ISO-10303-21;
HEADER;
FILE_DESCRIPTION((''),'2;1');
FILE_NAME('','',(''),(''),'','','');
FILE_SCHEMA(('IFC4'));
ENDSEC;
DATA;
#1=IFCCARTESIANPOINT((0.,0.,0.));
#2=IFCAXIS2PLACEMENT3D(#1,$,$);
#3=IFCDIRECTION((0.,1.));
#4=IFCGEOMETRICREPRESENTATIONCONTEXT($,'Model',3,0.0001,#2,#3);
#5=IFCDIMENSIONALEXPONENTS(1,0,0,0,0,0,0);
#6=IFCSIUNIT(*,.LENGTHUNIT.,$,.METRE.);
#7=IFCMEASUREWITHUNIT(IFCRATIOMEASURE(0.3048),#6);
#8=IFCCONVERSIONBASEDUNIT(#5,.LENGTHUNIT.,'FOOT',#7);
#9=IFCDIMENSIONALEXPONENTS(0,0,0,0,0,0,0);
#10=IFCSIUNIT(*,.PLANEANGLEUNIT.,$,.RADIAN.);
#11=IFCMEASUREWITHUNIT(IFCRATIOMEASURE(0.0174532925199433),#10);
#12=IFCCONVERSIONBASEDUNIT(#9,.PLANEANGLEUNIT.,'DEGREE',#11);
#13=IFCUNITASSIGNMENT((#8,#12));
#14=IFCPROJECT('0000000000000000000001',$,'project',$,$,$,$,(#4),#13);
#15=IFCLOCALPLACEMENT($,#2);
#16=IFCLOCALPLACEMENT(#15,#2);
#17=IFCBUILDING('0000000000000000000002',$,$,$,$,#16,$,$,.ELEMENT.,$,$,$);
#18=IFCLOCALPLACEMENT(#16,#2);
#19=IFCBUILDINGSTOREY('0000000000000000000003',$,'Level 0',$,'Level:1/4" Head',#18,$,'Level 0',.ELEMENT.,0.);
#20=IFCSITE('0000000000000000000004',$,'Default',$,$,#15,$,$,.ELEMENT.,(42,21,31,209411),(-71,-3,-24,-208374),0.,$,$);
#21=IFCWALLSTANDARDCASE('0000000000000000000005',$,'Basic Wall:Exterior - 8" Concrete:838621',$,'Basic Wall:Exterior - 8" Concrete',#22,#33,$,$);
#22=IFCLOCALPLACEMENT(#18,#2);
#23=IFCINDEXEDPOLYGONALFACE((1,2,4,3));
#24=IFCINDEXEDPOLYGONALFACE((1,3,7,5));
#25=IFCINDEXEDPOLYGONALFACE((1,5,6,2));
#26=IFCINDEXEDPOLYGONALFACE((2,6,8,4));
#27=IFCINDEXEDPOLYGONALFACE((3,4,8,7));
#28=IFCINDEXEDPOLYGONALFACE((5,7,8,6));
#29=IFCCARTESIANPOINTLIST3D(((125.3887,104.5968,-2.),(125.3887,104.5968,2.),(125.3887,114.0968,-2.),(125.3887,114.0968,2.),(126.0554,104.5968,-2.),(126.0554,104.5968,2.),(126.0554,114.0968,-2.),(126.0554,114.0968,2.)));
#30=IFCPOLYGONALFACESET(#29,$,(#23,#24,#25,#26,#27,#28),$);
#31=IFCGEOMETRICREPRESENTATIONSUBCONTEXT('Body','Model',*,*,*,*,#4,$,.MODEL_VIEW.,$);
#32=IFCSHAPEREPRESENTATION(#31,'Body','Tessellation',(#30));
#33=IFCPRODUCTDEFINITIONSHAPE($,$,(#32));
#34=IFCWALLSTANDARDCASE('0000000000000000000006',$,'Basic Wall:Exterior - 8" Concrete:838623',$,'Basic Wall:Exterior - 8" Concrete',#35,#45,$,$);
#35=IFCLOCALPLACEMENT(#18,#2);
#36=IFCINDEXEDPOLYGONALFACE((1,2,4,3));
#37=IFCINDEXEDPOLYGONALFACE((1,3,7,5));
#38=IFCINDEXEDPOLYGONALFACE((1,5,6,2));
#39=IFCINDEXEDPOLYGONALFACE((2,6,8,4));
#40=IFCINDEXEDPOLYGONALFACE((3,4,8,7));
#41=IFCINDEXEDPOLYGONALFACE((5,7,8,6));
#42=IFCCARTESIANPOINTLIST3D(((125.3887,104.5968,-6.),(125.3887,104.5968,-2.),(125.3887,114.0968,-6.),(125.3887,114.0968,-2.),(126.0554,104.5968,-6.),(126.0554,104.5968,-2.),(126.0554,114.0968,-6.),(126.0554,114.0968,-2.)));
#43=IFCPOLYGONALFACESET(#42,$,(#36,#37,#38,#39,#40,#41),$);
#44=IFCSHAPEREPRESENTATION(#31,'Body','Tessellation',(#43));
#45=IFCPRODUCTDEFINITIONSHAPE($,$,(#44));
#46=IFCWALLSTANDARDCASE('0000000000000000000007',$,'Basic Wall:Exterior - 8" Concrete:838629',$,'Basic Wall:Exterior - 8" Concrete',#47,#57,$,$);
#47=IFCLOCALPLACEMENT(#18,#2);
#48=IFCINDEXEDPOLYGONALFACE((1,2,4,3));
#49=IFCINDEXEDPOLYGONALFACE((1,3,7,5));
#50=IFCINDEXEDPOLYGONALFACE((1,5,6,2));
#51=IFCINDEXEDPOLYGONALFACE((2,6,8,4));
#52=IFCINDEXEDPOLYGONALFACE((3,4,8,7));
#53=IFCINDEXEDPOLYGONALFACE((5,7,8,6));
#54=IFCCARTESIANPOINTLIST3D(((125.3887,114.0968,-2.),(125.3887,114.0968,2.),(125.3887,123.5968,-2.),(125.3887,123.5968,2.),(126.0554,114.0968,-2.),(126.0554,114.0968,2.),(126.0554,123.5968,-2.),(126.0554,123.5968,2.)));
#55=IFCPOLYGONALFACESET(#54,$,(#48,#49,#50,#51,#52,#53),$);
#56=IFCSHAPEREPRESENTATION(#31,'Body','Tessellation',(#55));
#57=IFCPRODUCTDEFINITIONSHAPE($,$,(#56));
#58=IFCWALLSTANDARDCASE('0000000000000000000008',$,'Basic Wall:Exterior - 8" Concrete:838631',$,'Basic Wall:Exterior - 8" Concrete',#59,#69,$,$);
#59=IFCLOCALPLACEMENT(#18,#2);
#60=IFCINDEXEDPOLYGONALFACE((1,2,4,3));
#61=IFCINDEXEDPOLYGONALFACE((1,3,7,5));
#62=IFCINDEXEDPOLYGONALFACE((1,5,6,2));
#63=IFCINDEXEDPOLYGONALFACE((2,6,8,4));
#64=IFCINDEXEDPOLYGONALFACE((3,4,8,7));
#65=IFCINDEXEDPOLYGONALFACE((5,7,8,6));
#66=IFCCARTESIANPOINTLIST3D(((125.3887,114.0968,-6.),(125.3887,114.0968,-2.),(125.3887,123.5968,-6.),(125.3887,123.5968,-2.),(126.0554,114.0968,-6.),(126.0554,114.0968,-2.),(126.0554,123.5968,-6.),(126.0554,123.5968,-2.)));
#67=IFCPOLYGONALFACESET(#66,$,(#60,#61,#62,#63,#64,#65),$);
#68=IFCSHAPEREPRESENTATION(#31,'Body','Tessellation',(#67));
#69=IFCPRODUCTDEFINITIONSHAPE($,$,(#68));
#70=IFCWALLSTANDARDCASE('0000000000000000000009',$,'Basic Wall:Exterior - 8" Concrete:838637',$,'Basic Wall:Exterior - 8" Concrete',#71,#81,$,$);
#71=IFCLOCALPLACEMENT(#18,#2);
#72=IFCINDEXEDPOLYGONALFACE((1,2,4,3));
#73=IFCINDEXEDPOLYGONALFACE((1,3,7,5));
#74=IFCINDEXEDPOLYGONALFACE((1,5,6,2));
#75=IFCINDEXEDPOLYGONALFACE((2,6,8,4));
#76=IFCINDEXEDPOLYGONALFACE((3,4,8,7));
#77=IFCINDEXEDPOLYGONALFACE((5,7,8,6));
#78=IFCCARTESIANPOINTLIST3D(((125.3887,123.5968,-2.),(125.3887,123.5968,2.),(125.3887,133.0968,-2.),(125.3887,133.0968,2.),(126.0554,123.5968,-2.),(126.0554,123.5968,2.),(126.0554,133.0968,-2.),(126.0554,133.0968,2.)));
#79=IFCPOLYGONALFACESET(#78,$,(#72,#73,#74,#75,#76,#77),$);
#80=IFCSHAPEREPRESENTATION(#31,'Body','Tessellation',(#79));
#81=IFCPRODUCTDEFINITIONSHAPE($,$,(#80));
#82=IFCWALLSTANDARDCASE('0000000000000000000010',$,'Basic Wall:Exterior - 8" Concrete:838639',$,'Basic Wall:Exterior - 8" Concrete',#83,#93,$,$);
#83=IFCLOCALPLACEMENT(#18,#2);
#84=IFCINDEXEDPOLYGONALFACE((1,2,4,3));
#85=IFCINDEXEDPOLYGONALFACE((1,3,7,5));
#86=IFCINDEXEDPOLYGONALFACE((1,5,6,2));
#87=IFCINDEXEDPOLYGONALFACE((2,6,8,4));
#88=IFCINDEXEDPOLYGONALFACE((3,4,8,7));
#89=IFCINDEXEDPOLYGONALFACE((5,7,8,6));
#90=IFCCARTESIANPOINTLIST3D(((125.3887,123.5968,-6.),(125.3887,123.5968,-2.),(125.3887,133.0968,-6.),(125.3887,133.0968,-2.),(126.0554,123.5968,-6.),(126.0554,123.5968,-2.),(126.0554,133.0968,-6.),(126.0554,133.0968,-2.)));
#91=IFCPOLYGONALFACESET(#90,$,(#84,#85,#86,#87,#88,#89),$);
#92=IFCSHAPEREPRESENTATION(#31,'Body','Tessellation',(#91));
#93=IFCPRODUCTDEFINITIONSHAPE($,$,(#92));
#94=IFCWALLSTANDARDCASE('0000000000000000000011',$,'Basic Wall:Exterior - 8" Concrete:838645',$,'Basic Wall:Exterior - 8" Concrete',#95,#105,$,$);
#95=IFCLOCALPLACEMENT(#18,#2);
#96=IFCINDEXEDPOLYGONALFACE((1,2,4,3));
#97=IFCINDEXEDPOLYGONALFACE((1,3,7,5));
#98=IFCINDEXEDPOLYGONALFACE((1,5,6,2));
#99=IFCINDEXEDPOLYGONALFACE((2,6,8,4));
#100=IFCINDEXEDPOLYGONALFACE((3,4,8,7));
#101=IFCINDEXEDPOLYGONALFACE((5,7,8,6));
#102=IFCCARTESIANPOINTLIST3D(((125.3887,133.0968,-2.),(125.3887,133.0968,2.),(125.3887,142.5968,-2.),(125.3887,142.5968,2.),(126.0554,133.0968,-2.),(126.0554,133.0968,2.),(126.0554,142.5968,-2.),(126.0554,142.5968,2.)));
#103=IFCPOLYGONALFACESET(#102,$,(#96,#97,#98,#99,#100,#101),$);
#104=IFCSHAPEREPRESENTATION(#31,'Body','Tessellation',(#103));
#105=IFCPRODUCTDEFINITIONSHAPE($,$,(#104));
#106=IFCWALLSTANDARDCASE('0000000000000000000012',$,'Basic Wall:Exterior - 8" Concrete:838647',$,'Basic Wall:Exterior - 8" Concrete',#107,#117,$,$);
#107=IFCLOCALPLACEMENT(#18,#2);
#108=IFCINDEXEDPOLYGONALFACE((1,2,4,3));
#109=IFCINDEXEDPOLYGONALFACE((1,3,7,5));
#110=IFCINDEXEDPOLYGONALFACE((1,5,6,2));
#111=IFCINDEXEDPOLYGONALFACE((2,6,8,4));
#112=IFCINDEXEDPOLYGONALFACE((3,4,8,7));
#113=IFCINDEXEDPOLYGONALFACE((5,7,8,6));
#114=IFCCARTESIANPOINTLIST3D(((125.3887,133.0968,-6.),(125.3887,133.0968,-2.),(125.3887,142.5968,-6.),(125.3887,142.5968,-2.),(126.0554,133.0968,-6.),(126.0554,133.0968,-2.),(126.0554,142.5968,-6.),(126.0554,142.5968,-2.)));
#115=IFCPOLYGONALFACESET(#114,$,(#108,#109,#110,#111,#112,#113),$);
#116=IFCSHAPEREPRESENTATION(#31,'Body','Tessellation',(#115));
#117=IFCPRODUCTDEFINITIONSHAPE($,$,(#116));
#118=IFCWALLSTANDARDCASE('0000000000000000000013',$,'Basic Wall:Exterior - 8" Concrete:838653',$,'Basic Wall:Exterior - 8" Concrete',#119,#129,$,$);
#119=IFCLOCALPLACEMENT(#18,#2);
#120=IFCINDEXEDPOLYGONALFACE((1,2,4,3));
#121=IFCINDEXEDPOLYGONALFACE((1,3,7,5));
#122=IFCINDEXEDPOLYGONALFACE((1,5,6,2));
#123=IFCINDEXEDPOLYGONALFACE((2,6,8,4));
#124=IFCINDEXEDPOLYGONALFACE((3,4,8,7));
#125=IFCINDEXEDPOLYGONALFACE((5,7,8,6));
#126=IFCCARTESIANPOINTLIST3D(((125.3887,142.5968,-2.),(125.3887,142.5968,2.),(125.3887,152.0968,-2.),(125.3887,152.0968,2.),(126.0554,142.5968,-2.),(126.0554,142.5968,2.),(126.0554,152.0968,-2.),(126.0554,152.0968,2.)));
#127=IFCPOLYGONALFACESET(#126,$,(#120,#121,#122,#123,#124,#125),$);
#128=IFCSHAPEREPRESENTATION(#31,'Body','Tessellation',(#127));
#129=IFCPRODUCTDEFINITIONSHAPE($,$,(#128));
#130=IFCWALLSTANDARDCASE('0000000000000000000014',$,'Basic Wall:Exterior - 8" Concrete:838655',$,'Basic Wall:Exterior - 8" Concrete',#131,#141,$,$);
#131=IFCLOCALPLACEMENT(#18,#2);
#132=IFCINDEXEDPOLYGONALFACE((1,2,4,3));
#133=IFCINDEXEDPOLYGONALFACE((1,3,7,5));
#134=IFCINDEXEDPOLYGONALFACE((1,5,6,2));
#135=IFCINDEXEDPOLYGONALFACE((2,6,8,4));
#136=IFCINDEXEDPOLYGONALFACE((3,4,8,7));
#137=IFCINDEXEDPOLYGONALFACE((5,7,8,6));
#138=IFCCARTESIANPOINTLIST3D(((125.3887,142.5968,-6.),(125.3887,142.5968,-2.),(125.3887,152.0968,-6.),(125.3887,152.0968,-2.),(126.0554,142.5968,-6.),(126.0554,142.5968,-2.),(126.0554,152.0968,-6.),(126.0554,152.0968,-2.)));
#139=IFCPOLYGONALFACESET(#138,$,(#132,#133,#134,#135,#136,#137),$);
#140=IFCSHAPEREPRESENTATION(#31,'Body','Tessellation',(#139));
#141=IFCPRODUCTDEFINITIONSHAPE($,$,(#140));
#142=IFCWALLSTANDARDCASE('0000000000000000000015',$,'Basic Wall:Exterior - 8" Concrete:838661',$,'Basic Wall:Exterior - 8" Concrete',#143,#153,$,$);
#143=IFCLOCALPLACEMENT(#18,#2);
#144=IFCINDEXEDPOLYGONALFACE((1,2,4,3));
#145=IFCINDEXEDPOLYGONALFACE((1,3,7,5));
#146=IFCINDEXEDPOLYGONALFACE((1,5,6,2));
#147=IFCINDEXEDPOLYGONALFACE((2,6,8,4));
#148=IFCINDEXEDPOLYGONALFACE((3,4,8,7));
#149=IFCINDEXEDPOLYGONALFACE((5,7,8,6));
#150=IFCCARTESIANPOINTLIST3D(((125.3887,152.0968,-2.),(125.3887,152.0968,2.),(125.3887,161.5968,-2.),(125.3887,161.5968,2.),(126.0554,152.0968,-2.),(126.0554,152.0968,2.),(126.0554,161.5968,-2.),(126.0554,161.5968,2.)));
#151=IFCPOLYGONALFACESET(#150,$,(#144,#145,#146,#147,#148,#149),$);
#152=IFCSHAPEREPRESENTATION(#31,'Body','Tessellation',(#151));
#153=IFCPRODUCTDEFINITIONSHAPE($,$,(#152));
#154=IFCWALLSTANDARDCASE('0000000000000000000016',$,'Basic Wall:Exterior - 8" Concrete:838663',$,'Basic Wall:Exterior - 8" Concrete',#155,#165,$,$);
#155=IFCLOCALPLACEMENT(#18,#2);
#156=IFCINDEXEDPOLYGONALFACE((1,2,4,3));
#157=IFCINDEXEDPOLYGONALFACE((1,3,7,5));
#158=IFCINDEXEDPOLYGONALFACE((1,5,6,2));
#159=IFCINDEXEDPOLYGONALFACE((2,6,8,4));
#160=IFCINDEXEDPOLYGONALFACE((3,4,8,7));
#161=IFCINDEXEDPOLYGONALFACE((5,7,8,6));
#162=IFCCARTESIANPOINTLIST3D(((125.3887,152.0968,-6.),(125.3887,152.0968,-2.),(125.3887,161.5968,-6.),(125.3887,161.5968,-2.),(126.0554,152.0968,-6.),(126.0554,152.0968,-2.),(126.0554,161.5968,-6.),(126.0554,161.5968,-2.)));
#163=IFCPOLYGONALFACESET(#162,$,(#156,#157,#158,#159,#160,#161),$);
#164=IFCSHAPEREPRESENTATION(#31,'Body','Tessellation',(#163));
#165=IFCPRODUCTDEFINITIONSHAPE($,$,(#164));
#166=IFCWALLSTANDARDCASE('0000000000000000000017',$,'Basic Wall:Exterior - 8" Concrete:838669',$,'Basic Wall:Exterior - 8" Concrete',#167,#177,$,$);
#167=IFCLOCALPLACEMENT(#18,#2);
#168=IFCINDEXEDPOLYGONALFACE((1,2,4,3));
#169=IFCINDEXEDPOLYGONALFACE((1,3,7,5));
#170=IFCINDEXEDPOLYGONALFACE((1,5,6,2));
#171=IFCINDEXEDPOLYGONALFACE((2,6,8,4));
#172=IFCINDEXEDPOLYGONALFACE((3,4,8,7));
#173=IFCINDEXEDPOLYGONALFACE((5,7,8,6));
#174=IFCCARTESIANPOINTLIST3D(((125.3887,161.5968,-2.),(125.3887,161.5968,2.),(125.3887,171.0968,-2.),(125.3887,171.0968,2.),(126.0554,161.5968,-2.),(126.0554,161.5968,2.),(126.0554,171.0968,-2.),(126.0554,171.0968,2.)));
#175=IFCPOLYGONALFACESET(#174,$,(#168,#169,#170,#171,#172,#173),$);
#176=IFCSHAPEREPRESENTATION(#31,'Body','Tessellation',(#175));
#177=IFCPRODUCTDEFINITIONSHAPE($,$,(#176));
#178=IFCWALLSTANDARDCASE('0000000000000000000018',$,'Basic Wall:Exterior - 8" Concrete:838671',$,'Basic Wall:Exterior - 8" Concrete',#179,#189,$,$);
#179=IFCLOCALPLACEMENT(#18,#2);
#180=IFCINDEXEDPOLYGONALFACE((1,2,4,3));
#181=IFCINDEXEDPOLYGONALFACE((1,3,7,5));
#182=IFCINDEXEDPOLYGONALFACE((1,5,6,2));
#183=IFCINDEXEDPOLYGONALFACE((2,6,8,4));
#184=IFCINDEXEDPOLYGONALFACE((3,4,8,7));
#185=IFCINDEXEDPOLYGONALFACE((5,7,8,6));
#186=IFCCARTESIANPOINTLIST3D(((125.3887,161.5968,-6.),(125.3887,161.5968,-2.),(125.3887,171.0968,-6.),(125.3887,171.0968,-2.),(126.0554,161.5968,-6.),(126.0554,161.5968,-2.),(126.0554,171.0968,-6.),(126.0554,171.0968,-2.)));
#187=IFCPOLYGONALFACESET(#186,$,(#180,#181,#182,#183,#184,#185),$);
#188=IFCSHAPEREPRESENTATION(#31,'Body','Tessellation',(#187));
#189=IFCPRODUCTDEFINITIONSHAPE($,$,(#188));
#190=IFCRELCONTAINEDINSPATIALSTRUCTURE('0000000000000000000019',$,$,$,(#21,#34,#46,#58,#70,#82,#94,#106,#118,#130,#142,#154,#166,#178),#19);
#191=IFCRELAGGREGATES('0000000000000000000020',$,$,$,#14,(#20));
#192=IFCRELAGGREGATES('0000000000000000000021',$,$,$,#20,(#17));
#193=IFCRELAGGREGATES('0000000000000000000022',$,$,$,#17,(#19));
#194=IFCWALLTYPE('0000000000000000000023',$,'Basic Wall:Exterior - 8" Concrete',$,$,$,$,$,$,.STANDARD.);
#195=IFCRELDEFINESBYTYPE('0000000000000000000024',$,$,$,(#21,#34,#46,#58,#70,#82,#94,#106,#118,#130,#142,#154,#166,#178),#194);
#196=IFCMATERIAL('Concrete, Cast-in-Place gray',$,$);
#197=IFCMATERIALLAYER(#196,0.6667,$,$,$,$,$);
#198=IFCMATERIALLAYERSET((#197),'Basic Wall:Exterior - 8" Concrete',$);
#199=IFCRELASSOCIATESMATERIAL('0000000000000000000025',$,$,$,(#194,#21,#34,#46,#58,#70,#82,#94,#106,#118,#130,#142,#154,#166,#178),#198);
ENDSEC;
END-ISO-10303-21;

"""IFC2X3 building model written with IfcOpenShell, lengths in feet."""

from ifc_helpers import new_model, entity, si_unit, converted_unit, direction, frame, frame_2d, origin, place, context, subcontext, project, spatial, rectangle, extrude, material, layer, layer_set, layer_usage, type_object, element, save


model = new_model("IFC2X3")

# Units and contexts
model_context = context("Model", 3, precision=0.0001, world=origin(), true_north=direction((0.0, 1.0)))
body_context = subcontext(model_context, "Body", "Model", "MODEL_VIEW")
ifc_project = project(units=[converted_unit("LENGTHUNIT", "FOOT", entity("IfcRatioMeasure", 0.3048), si_unit("LENGTHUNIT", "METRE"), dimensions=[1, 0, 0, 0, 0, 0, 0]), converted_unit("PLANEANGLEUNIT", "DEGREE", entity("IfcRatioMeasure", 0.0174532925199433), si_unit("PLANEANGLEUNIT", "RADIAN"), dimensions=[0, 0, 0, 0, 0, 0, 0])], contexts=[model_context])

# Site, building, storey
site_placement = place(None, origin())
site = spatial("IfcSite", under=ifc_project, at=site_placement, Name="Default", CompositionType="ELEMENT", RefLatitude=(42, 21, 31, 209411), RefLongitude=(-71, -3, -24, -208374), RefElevation=0.0)
building_placement = place(site_placement, origin())
building = spatial("IfcBuilding", under=site, at=building_placement, CompositionType="ELEMENT")
storey_placement = place(building_placement, origin())
storey = spatial("IfcBuildingStorey", under=building, at=storey_placement, Name="Level 0", ObjectType="Level:1/4\" Head", LongName="Level 0", CompositionType="ELEMENT", Elevation=0.0)

# Walls
ifc_material_1 = material(Name="Concrete, Cast-in-Place gray")
ifc_layer = layer(ifc_material_1, 0.6667)
ifc_layer_set = layer_set([ifc_layer], Name="Basic Wall:Exterior - 8\" Concrete")
ifc_layer_usage_1 = layer_usage(ifc_layer_set, "AXIS2", "NEGATIVE", 0.3333)
wall_type = type_object("IfcWallType", Name="Basic Wall:Exterior - 8\" Concrete", PredefinedType="STANDARD", material=ifc_layer_set)
wall_1_placement = place(storey_placement, frame((125.722, 104.5968, -2.0), z_axis=(0.0, 0.0, 1.0), x_axis=(0.0, 1.0, 0.0)))
element("IfcWallStandardCase", 1, at=wall_1_placement, inside=storey, type_object=wall_type, material=ifc_layer_usage_1, Name="Basic Wall:Exterior - 8\" Concrete:838621", ObjectType="Basic Wall:Exterior - 8\" Concrete", context=body_context, shape_type="SweptSolid", body=[
    extrude(rectangle(XDim=9.5, YDim=0.6667, at=frame_2d((4.75, 0.0), x_axis=(-1.0, 0.0))), origin(), (0.0, 0.0, 1.0), 4.0),
])
ifc_layer_usage_2 = layer_usage(ifc_layer_set, "AXIS2", "NEGATIVE", 0.3333)
wall_2_placement = place(storey_placement, frame((125.722, 104.5968, -6.0), z_axis=(0.0, 0.0, 1.0), x_axis=(0.0, 1.0, 0.0)))
element("IfcWallStandardCase", 2, at=wall_2_placement, inside=storey, type_object=wall_type, material=ifc_layer_usage_2, Name="Basic Wall:Exterior - 8\" Concrete:838623", ObjectType="Basic Wall:Exterior - 8\" Concrete", context=body_context, shape_type="SweptSolid", body=[
    extrude(rectangle(XDim=9.5, YDim=0.6667, at=frame_2d((4.75, 0.0), x_axis=(-1.0, 0.0))), origin(), (0.0, 0.0, 1.0), 4.0),
])
ifc_layer_usage_3 = layer_usage(ifc_layer_set, "AXIS2", "NEGATIVE", 0.3333)
wall_3_placement = place(storey_placement, frame((125.722, 114.0968, -2.0), z_axis=(0.0, 0.0, 1.0), x_axis=(0.0, 1.0, 0.0)))
element("IfcWallStandardCase", 3, at=wall_3_placement, inside=storey, type_object=wall_type, material=ifc_layer_usage_3, Name="Basic Wall:Exterior - 8\" Concrete:838629", ObjectType="Basic Wall:Exterior - 8\" Concrete", context=body_context, shape_type="SweptSolid", body=[
    extrude(rectangle(XDim=9.5, YDim=0.6667, at=frame_2d((4.75, 0.0), x_axis=(-1.0, 0.0))), origin(), (0.0, 0.0, 1.0), 4.0),
])
ifc_layer_usage_4 = layer_usage(ifc_layer_set, "AXIS2", "NEGATIVE", 0.3333)
wall_4_placement = place(storey_placement, frame((125.722, 114.0968, -6.0), z_axis=(0.0, 0.0, 1.0), x_axis=(0.0, 1.0, 0.0)))
element("IfcWallStandardCase", 4, at=wall_4_placement, inside=storey, type_object=wall_type, material=ifc_layer_usage_4, Name="Basic Wall:Exterior - 8\" Concrete:838631", ObjectType="Basic Wall:Exterior - 8\" Concrete", context=body_context, shape_type="SweptSolid", body=[
    extrude(rectangle(XDim=9.5, YDim=0.6667, at=frame_2d((4.75, 0.0), x_axis=(-1.0, 0.0))), origin(), (0.0, 0.0, 1.0), 4.0),
])
ifc_layer_usage_5 = layer_usage(ifc_layer_set, "AXIS2", "NEGATIVE", 0.3333)
wall_5_placement = place(storey_placement, frame((125.722, 123.5968, -2.0), z_axis=(0.0, 0.0, 1.0), x_axis=(0.0, 1.0, 0.0)))
element("IfcWallStandardCase", 5, at=wall_5_placement, inside=storey, type_object=wall_type, material=ifc_layer_usage_5, Name="Basic Wall:Exterior - 8\" Concrete:838637", ObjectType="Basic Wall:Exterior - 8\" Concrete", context=body_context, shape_type="SweptSolid", body=[
    extrude(rectangle(XDim=9.5, YDim=0.6667, at=frame_2d((4.75, 0.0), x_axis=(-1.0, 0.0))), origin(), (0.0, 0.0, 1.0), 4.0),
])
ifc_layer_usage_6 = layer_usage(ifc_layer_set, "AXIS2", "NEGATIVE", 0.3333)
wall_6_placement = place(storey_placement, frame((125.722, 123.5968, -6.0), z_axis=(0.0, 0.0, 1.0), x_axis=(0.0, 1.0, 0.0)))
element("IfcWallStandardCase", 6, at=wall_6_placement, inside=storey, type_object=wall_type, material=ifc_layer_usage_6, Name="Basic Wall:Exterior - 8\" Concrete:838639", ObjectType="Basic Wall:Exterior - 8\" Concrete", context=body_context, shape_type="SweptSolid", body=[
    extrude(rectangle(XDim=9.5, YDim=0.6667, at=frame_2d((4.75, 0.0), x_axis=(-1.0, 0.0))), origin(), (0.0, 0.0, 1.0), 4.0),
])
ifc_layer_usage_7 = layer_usage(ifc_layer_set, "AXIS2", "NEGATIVE", 0.3333)
wall_7_placement = place(storey_placement, frame((125.722, 133.0968, -2.0), z_axis=(0.0, 0.0, 1.0), x_axis=(0.0, 1.0, 0.0)))
element("IfcWallStandardCase", 7, at=wall_7_placement, inside=storey, type_object=wall_type, material=ifc_layer_usage_7, Name="Basic Wall:Exterior - 8\" Concrete:838645", ObjectType="Basic Wall:Exterior - 8\" Concrete", context=body_context, shape_type="SweptSolid", body=[
    extrude(rectangle(XDim=9.5, YDim=0.6667, at=frame_2d((4.75, 0.0), x_axis=(-1.0, 0.0))), origin(), (0.0, 0.0, 1.0), 4.0),
])
ifc_layer_usage_8 = layer_usage(ifc_layer_set, "AXIS2", "NEGATIVE", 0.3333)
wall_8_placement = place(storey_placement, frame((125.722, 133.0968, -6.0), z_axis=(0.0, 0.0, 1.0), x_axis=(0.0, 1.0, 0.0)))
element("IfcWallStandardCase", 8, at=wall_8_placement, inside=storey, type_object=wall_type, material=ifc_layer_usage_8, Name="Basic Wall:Exterior - 8\" Concrete:838647", ObjectType="Basic Wall:Exterior - 8\" Concrete", context=body_context, shape_type="SweptSolid", body=[
    extrude(rectangle(XDim=9.5, YDim=0.6667, at=frame_2d((4.75, 0.0), x_axis=(-1.0, 0.0))), origin(), (0.0, 0.0, 1.0), 4.0),
])
ifc_layer_usage_9 = layer_usage(ifc_layer_set, "AXIS2", "NEGATIVE", 0.3333)
wall_9_placement = place(storey_placement, frame((125.722, 142.5968, -2.0), z_axis=(0.0, 0.0, 1.0), x_axis=(0.0, 1.0, 0.0)))
element("IfcWallStandardCase", 9, at=wall_9_placement, inside=storey, type_object=wall_type, material=ifc_layer_usage_9, Name="Basic Wall:Exterior - 8\" Concrete:838653", ObjectType="Basic Wall:Exterior - 8\" Concrete", context=body_context, shape_type="SweptSolid", body=[
    extrude(rectangle(XDim=9.5, YDim=0.6667, at=frame_2d((4.75, 0.0), x_axis=(-1.0, 0.0))), origin(), (0.0, 0.0, 1.0), 4.0),
])
ifc_layer_usage_10 = layer_usage(ifc_layer_set, "AXIS2", "NEGATIVE", 0.3333)
wall_10_placement = place(storey_placement, frame((125.722, 142.5968, -6.0), z_axis=(0.0, 0.0, 1.0), x_axis=(0.0, 1.0, 0.0)))
element("IfcWallStandardCase", 10, at=wall_10_placement, inside=storey, type_object=wall_type, material=ifc_layer_usage_10, Name="Basic Wall:Exterior - 8\" Concrete:838655", ObjectType="Basic Wall:Exterior - 8\" Concrete", context=body_context, shape_type="SweptSolid", body=[
    extrude(rectangle(XDim=9.5, YDim=0.6667, at=frame_2d((4.75, 0.0), x_axis=(-1.0, 0.0))), origin(), (0.0, 0.0, 1.0), 4.0),
])
ifc_layer_usage_11 = layer_usage(ifc_layer_set, "AXIS2", "NEGATIVE", 0.3333)
wall_11_placement = place(storey_placement, frame((125.722, 152.0968, -2.0), z_axis=(0.0, 0.0, 1.0), x_axis=(0.0, 1.0, 0.0)))
element("IfcWallStandardCase", 11, at=wall_11_placement, inside=storey, type_object=wall_type, material=ifc_layer_usage_11, Name="Basic Wall:Exterior - 8\" Concrete:838661", ObjectType="Basic Wall:Exterior - 8\" Concrete", context=body_context, shape_type="SweptSolid", body=[
    extrude(rectangle(XDim=9.5, YDim=0.6667, at=frame_2d((4.75, 0.0), x_axis=(-1.0, 0.0))), origin(), (0.0, 0.0, 1.0), 4.0),
])
ifc_layer_usage_12 = layer_usage(ifc_layer_set, "AXIS2", "NEGATIVE", 0.3333)
wall_12_placement = place(storey_placement, frame((125.722, 152.0968, -6.0), z_axis=(0.0, 0.0, 1.0), x_axis=(0.0, 1.0, 0.0)))
element("IfcWallStandardCase", 12, at=wall_12_placement, inside=storey, type_object=wall_type, material=ifc_layer_usage_12, Name="Basic Wall:Exterior - 8\" Concrete:838663", ObjectType="Basic Wall:Exterior - 8\" Concrete", context=body_context, shape_type="SweptSolid", body=[
    extrude(rectangle(XDim=9.5, YDim=0.6667, at=frame_2d((4.75, 0.0), x_axis=(-1.0, 0.0))), origin(), (0.0, 0.0, 1.0), 4.0),
])
ifc_layer_usage_13 = layer_usage(ifc_layer_set, "AXIS2", "NEGATIVE", 0.3333)
wall_13_placement = place(storey_placement, frame((125.722, 161.5968, -2.0), z_axis=(0.0, 0.0, 1.0), x_axis=(0.0, 1.0, 0.0)))
element("IfcWallStandardCase", 13, at=wall_13_placement, inside=storey, type_object=wall_type, material=ifc_layer_usage_13, Name="Basic Wall:Exterior - 8\" Concrete:838669", ObjectType="Basic Wall:Exterior - 8\" Concrete", context=body_context, shape_type="SweptSolid", body=[
    extrude(rectangle(XDim=9.5, YDim=0.6667, at=frame_2d((4.75, 0.0), x_axis=(-1.0, 0.0))), origin(), (0.0, 0.0, 1.0), 4.0),
])
ifc_layer_usage_14 = layer_usage(ifc_layer_set, "AXIS2", "NEGATIVE", 0.3333)
wall_14_placement = place(storey_placement, frame((125.722, 161.5968, -6.0), z_axis=(0.0, 0.0, 1.0), x_axis=(0.0, 1.0, 0.0)))
element("IfcWallStandardCase", 14, at=wall_14_placement, inside=storey, type_object=wall_type, material=ifc_layer_usage_14, Name="Basic Wall:Exterior - 8\" Concrete:838671", ObjectType="Basic Wall:Exterior - 8\" Concrete", context=body_context, shape_type="SweptSolid", body=[
    extrude(rectangle(XDim=9.5, YDim=0.6667, at=frame_2d((4.75, 0.0), x_axis=(-1.0, 0.0))), origin(), (0.0, 0.0, 1.0), 4.0),
])

save(model, "model.ifc")
